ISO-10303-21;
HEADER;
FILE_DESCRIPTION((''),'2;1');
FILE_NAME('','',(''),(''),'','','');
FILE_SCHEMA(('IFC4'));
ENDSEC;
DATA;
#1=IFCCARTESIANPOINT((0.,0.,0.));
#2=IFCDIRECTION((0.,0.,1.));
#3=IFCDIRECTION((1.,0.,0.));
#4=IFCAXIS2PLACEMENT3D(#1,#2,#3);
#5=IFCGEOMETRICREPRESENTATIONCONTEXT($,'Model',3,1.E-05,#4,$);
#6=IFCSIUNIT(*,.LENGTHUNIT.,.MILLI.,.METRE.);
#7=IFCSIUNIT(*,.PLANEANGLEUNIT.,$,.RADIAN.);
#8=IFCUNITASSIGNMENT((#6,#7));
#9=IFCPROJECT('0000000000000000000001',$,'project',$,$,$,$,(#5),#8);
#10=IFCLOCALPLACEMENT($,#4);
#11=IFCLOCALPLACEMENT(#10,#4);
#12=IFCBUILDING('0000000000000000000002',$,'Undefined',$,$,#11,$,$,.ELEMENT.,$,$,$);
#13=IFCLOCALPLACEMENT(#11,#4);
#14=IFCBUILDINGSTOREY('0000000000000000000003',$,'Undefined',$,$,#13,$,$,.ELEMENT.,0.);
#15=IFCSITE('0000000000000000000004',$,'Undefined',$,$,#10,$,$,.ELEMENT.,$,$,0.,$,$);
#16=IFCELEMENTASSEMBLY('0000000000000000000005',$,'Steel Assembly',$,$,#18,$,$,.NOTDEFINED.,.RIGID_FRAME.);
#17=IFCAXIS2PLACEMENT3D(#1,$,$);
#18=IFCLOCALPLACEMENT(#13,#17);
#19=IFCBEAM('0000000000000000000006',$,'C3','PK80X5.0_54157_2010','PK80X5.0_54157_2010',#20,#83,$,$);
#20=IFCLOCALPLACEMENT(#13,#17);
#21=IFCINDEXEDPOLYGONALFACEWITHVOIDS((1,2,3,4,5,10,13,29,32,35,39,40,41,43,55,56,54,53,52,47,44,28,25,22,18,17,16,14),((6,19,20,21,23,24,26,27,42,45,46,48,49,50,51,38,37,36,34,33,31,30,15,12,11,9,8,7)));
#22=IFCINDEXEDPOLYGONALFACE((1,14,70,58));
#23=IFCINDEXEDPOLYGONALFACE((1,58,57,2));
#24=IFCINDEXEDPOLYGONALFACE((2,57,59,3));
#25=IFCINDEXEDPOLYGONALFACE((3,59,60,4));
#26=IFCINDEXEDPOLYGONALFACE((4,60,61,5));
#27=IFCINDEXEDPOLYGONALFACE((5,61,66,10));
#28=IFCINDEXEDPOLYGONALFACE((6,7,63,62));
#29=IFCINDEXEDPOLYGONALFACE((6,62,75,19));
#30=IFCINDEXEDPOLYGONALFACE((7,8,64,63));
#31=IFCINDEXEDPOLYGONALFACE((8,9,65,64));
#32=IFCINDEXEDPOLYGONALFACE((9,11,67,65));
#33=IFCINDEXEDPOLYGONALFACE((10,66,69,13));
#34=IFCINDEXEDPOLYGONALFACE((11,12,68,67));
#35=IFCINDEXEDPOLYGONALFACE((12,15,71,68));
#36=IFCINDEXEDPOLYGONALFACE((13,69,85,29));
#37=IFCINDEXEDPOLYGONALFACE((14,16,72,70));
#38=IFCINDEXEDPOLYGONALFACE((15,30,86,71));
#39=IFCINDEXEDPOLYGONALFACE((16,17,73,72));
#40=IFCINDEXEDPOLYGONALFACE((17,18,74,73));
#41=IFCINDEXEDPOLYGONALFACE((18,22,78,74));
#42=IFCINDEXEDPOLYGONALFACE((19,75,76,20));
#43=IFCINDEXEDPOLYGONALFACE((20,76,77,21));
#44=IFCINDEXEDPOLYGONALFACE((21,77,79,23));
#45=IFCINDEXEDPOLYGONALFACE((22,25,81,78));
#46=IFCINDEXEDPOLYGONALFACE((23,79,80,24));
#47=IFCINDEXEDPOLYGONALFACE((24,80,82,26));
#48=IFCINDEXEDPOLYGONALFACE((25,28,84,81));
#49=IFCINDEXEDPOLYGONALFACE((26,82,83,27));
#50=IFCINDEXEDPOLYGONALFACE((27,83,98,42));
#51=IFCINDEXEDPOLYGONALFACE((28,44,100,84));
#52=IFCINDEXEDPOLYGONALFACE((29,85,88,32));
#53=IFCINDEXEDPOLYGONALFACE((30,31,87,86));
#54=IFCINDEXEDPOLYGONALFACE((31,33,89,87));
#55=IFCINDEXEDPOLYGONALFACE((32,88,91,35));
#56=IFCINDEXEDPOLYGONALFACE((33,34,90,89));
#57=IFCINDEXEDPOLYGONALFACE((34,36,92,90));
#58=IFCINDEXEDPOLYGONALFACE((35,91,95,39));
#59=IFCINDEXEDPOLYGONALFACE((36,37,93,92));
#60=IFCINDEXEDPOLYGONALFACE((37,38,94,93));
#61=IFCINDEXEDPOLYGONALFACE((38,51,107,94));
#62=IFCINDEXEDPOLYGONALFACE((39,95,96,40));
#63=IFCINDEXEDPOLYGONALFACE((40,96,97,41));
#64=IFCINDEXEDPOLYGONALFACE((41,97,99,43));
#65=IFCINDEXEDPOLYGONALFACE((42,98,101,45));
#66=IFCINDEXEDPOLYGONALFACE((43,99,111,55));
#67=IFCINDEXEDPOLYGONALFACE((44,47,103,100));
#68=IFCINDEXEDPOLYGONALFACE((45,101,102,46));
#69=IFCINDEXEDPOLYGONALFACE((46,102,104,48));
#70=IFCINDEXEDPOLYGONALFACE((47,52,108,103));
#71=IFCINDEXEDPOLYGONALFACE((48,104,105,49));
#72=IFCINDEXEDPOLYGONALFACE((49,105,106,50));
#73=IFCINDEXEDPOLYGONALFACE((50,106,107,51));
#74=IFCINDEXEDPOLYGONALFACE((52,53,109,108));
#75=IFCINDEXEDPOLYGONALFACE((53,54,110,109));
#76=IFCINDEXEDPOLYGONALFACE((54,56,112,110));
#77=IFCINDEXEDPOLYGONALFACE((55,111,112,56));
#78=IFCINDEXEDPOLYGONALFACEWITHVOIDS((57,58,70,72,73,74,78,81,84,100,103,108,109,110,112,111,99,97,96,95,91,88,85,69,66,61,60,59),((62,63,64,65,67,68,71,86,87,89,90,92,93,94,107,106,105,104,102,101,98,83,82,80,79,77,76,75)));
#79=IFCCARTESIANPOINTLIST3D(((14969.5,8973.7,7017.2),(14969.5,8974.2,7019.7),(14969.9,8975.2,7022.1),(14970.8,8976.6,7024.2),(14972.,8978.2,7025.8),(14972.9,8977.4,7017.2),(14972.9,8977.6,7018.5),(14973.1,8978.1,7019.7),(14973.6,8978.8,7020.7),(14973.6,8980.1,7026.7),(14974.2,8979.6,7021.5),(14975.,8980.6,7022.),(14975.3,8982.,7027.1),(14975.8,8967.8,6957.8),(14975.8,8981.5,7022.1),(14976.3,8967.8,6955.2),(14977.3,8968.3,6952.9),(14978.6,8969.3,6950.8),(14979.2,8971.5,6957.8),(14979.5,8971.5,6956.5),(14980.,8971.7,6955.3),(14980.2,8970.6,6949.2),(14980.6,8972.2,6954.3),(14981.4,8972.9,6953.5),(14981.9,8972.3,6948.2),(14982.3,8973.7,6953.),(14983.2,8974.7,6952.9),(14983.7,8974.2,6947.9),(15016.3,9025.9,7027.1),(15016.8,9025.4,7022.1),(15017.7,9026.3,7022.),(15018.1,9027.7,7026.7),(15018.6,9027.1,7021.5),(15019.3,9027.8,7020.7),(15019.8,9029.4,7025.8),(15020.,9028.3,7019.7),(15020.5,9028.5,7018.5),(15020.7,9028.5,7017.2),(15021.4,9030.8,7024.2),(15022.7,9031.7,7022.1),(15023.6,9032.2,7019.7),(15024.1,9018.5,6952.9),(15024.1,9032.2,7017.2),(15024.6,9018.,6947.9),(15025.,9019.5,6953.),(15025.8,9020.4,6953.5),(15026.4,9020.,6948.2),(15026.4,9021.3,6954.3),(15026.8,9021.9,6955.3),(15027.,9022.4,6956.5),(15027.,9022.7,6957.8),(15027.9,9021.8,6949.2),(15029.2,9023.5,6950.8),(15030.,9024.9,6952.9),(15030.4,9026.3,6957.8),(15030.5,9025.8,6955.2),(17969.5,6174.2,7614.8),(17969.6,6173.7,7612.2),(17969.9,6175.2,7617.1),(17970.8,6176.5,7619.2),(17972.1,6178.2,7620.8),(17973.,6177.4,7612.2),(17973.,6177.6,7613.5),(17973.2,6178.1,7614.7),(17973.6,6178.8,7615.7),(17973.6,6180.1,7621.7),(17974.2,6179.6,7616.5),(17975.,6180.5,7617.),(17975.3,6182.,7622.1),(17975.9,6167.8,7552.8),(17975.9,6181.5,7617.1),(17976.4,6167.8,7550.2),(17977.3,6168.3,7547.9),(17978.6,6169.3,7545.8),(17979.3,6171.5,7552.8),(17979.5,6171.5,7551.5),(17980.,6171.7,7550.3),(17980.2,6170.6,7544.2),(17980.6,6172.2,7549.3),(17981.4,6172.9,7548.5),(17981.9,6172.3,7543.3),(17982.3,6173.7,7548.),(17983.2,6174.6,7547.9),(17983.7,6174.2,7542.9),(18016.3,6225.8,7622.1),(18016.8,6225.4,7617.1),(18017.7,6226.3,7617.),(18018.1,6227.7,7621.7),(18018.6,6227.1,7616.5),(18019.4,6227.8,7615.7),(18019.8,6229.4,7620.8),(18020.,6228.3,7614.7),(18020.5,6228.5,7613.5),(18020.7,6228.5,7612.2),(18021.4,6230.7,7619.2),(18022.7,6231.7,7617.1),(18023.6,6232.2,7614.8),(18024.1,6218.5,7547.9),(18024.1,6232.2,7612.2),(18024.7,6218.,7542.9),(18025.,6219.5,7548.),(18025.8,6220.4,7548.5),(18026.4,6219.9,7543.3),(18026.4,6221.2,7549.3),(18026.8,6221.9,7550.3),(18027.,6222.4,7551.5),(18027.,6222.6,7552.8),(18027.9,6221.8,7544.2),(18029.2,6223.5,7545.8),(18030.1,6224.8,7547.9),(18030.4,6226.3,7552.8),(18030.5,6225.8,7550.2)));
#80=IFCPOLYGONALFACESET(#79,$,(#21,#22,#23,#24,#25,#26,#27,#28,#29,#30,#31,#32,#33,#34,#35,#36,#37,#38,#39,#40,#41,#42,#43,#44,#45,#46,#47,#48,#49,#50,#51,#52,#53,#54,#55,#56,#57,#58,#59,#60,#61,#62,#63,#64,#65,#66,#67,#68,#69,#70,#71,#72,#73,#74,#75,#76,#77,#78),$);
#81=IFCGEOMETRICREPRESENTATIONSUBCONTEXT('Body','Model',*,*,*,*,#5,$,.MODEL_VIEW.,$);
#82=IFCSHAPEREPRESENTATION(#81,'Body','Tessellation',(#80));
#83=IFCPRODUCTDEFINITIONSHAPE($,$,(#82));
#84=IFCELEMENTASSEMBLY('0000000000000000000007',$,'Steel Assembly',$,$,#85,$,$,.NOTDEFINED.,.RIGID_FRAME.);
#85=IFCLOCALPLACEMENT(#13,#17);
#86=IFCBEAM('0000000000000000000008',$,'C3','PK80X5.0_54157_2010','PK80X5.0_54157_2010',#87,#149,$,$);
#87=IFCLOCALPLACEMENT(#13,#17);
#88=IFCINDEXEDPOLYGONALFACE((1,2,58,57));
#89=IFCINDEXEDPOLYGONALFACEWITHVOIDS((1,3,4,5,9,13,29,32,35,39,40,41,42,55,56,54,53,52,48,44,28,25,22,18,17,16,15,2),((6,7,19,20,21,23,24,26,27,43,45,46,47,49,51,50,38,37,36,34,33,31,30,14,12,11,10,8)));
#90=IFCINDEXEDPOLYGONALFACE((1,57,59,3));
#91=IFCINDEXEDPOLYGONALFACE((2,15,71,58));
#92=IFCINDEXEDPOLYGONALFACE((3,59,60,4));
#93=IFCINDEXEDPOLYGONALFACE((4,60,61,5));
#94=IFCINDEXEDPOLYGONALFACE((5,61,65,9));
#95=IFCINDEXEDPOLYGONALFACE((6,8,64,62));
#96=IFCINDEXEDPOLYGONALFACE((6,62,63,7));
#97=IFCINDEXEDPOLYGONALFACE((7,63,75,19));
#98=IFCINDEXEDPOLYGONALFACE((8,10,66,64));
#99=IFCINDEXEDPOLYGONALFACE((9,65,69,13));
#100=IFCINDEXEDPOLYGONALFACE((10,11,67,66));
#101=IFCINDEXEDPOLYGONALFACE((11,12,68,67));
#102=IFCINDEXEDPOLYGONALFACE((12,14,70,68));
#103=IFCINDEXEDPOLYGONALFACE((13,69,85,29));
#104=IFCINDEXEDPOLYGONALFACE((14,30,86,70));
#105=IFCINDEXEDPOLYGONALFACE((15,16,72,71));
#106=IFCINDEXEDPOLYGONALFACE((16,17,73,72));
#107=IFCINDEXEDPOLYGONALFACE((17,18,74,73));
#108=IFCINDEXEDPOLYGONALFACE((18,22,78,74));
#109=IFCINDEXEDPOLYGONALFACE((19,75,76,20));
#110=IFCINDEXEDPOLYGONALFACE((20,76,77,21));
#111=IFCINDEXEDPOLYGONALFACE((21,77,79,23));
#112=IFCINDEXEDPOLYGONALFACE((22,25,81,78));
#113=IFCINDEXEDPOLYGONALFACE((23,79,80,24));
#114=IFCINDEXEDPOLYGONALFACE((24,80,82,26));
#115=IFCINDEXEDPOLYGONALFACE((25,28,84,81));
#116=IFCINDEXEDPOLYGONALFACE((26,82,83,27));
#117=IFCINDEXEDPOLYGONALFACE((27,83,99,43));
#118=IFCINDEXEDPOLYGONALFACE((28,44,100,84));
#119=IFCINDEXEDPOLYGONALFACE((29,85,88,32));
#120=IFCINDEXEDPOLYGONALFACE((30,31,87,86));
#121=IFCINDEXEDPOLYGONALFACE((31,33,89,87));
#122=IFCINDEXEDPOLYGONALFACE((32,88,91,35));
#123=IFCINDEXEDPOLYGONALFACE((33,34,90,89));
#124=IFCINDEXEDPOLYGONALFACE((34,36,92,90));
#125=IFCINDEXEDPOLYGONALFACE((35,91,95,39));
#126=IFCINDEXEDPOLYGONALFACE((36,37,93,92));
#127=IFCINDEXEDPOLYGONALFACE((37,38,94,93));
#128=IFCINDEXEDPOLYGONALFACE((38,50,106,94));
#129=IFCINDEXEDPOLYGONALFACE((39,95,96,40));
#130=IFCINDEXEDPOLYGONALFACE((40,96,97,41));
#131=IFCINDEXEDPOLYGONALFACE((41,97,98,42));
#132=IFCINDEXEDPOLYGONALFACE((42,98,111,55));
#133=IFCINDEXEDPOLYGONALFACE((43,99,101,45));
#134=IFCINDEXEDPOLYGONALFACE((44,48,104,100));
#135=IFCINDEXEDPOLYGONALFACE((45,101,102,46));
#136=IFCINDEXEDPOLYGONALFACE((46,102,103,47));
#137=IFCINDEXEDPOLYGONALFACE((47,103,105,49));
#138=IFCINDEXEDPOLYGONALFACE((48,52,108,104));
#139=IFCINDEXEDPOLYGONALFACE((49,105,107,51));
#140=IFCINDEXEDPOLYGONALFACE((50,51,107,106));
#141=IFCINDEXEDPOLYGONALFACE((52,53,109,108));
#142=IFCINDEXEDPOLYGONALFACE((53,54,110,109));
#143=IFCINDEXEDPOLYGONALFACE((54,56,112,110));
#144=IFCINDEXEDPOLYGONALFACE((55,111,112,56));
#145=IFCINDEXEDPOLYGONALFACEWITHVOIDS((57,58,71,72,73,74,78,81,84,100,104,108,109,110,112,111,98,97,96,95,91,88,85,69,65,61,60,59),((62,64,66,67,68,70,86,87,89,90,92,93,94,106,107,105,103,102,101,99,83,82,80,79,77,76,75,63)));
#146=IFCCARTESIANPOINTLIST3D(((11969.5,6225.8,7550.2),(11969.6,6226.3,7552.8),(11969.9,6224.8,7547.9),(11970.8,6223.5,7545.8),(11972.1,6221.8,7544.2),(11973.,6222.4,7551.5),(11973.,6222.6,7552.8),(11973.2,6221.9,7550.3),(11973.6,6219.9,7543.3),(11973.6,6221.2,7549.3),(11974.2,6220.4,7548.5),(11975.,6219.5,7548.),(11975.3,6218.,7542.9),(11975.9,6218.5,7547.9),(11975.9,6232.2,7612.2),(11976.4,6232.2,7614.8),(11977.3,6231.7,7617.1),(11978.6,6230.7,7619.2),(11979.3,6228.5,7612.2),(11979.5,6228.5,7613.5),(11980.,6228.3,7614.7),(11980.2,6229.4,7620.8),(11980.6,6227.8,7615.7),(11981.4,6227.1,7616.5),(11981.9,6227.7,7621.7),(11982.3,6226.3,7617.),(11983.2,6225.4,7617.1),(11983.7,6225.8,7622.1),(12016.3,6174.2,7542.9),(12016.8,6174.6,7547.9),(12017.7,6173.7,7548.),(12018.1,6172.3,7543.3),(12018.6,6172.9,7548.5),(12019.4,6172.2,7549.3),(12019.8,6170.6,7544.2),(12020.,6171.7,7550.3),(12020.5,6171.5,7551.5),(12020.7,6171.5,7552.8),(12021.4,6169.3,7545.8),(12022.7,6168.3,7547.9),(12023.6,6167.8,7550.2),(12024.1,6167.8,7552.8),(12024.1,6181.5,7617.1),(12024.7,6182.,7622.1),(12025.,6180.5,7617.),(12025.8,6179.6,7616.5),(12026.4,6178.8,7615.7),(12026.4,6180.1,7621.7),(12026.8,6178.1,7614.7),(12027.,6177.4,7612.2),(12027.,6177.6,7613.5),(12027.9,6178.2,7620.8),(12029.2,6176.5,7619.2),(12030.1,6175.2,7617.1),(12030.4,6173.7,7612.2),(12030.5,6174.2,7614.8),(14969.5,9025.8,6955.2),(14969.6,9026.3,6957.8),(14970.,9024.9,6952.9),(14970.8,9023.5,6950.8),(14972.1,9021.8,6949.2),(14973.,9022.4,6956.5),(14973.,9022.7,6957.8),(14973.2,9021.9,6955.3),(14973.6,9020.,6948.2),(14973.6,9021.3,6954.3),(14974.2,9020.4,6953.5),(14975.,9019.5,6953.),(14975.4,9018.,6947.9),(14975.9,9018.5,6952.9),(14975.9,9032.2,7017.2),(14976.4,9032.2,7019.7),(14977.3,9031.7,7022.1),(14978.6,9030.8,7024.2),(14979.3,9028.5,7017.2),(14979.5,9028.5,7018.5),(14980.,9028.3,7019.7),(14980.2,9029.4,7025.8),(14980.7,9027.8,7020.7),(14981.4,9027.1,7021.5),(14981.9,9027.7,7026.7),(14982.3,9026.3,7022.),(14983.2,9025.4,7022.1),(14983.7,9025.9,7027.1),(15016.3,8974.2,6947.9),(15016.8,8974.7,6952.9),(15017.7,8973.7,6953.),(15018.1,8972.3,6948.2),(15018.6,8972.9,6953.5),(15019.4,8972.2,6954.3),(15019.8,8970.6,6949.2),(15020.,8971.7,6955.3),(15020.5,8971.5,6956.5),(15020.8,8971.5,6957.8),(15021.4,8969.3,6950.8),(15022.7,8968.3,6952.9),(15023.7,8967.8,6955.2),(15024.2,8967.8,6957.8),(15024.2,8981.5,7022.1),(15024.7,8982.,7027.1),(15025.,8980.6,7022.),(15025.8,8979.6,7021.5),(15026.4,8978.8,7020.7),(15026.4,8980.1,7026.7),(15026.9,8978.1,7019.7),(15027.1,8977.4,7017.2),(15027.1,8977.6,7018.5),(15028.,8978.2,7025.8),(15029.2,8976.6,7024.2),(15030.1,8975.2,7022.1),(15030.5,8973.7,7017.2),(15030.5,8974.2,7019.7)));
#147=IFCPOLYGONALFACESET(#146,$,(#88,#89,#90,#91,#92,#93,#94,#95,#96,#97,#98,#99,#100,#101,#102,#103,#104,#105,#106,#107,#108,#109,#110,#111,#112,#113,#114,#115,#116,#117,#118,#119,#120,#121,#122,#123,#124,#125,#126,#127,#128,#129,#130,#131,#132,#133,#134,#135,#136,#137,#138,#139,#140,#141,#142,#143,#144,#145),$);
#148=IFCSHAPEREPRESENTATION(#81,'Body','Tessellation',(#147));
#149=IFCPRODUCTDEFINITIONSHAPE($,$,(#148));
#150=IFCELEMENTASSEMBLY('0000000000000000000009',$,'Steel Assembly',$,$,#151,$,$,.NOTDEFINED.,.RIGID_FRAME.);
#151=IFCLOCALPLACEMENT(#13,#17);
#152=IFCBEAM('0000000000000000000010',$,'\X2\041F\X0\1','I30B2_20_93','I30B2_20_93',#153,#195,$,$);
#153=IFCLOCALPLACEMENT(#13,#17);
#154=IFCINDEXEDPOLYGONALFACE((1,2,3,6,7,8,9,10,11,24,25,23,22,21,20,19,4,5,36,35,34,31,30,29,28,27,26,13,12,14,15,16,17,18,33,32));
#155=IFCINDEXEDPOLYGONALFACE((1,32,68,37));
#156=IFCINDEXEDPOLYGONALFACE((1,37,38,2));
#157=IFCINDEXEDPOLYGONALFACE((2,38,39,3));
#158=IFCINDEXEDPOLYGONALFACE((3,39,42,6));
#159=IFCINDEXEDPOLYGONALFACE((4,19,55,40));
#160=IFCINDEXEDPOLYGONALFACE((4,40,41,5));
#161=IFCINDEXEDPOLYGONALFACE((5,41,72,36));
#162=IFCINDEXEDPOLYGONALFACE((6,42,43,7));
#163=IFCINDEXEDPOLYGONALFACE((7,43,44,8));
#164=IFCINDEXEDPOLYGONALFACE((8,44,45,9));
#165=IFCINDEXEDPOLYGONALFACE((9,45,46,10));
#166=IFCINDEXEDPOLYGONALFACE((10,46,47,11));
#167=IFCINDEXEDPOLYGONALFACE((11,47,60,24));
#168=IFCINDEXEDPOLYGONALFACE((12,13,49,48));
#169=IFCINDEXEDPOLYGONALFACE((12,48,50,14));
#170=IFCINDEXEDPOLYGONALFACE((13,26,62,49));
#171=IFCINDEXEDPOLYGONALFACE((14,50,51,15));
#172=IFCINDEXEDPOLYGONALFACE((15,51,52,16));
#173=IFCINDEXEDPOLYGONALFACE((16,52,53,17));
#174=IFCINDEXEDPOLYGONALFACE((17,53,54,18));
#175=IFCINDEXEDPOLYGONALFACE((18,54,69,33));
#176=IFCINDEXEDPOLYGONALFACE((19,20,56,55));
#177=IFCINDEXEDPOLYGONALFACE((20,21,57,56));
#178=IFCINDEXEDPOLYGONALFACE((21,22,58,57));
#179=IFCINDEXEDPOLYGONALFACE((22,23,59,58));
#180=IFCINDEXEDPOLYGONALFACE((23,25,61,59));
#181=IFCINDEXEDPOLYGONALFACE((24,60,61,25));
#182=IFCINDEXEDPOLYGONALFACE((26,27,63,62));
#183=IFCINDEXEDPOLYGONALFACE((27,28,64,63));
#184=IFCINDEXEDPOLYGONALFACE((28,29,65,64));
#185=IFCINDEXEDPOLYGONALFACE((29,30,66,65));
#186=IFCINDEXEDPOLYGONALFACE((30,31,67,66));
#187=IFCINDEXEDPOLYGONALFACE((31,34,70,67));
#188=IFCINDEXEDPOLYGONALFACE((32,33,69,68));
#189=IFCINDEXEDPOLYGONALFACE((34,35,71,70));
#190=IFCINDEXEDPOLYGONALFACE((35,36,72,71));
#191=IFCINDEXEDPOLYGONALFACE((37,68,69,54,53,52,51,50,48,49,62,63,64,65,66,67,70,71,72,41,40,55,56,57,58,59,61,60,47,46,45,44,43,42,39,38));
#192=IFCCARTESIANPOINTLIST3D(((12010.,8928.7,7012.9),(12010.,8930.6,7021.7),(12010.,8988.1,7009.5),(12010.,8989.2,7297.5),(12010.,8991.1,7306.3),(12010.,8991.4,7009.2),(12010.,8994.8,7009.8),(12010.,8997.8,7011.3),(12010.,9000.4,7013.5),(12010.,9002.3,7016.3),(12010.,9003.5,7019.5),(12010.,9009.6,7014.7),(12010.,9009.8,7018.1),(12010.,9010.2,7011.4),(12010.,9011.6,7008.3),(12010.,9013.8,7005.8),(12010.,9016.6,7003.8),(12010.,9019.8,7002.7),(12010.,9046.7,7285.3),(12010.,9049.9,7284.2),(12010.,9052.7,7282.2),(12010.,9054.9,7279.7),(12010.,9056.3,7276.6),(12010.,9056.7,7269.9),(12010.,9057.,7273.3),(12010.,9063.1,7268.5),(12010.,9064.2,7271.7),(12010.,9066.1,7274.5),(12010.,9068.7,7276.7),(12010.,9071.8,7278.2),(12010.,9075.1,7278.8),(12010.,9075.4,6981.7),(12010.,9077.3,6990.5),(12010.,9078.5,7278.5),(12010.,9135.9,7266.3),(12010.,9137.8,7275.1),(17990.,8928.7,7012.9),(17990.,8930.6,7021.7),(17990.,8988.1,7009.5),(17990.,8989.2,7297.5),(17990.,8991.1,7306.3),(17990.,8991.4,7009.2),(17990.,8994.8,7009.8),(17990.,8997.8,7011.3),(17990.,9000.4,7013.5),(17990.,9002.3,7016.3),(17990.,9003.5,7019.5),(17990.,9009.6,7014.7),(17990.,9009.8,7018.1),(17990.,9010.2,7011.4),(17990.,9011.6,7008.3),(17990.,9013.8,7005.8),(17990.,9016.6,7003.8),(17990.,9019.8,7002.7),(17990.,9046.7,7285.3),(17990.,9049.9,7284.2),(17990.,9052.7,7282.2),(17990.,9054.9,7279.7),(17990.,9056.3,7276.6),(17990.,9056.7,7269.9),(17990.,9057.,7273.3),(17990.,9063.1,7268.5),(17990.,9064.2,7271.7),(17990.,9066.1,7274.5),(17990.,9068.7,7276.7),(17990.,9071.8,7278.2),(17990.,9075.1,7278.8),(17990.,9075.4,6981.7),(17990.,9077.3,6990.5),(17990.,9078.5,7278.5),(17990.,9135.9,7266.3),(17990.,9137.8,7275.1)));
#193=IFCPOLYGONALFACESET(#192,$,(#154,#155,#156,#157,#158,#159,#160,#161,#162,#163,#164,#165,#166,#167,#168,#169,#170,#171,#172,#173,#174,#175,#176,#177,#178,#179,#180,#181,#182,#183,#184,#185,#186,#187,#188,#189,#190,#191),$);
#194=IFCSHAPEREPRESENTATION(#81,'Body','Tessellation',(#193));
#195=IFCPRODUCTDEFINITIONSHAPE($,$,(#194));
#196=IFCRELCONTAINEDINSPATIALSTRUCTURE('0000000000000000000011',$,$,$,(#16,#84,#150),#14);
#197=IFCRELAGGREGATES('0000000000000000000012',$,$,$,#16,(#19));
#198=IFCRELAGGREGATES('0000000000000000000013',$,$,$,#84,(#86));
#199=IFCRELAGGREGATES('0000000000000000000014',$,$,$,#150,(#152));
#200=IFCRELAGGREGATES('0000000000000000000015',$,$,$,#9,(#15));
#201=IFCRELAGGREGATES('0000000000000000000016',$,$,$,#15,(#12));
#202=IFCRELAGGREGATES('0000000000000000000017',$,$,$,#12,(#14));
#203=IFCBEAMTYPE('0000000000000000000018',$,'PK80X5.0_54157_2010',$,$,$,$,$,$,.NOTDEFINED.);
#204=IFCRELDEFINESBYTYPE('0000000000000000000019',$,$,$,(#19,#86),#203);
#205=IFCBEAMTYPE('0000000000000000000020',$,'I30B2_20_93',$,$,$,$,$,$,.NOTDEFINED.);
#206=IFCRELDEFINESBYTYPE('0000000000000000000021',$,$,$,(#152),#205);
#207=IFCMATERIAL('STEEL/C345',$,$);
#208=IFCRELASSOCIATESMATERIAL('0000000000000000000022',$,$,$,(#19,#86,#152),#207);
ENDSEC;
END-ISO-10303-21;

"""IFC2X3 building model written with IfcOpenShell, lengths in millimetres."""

from ifc_helpers import new_model, si_unit, frame, origin_with_axes, origin_2d_with_axis, place, context, subcontext, project, spatial, hollow_rectangle, i_section, extrude, material, type_object, element, aggregate, save


model = new_model("IFC2X3")

# Units and contexts
model_context = context("Model", 3, precision=1e-05, world=origin_with_axes())
body_context = subcontext(model_context, "Body", "Model", "MODEL_VIEW")
ifc_project = project(units=[si_unit("LENGTHUNIT", "METRE", prefix="MILLI"), si_unit("PLANEANGLEUNIT", "RADIAN")], contexts=[model_context])

# Site, building, storey
site_placement = place(None, origin_with_axes())
site = spatial("IfcSite", under=ifc_project, at=site_placement, Name="Undefined", CompositionType="ELEMENT", RefElevation=0.0)
building_placement = place(site_placement, origin_with_axes())
building = spatial("IfcBuilding", under=site, at=building_placement, Name="Undefined", CompositionType="ELEMENT")
storey_placement = place(building_placement, origin_with_axes())
storey = spatial("IfcBuildingStorey", under=building, at=storey_placement, Name="Undefined", CompositionType="ELEMENT", Elevation=0.0)

# Element assemblies, beams
ifc_material = material(Name="STEEL/C345")
assembly_1_placement = place(storey_placement, origin_with_axes())
assembly_1 = element("IfcElementAssembly", 1, at=assembly_1_placement, inside=storey, Name="Steel Assembly", AssemblyPlace="NOTDEFINED", PredefinedType="RIGID_FRAME")
beam_type_1 = type_object("IfcBeamType", Name="PK80X5.0_54157_2010", PredefinedType="NOTDEFINED")
beam_1_placement = place(assembly_1_placement, frame((15000.0, 9000.0, 6987.5), z_axis=(-0.104901, 0.097907, 0.989651), x_axis=(0.72349, -0.675257, 0.143492)))
beam_1 = element("IfcBeam", 2, at=beam_1_placement, type_object=beam_type_1, material=ifc_material, Name="C3", Description="PK80X5.0_54157_2010", ObjectType="PK80X5.0_54157_2010", context=body_context, shape_type="SweptSolid", body=[
    extrude(hollow_rectangle(XDim=80.0, YDim=80.0, WallThickness=5.0, InnerFilletRadius=5.0, OuterFilletRadius=10.0, at=origin_2d_with_axis()), frame((4146.6, 0.0, 0.0), z_axis=(-1.0, 0.0, 0.0), x_axis=(0.0, -1.0, 0.0)), (0.0, 0.0, 1.0), 4146.6),
])
aggregate(assembly_1, [beam_1])
assembly_2_placement = place(storey_placement, origin_with_axes())
assembly_2 = element("IfcElementAssembly", 3, at=assembly_2_placement, inside=storey, Name="Steel Assembly", AssemblyPlace="NOTDEFINED", PredefinedType="RIGID_FRAME")
beam_2_placement = place(assembly_2_placement, frame((15000.0, 9000.0, 6987.5), z_axis=(0.104901, 0.097907, 0.989651), x_axis=(-0.72349, -0.675257, 0.143492)))
beam_2 = element("IfcBeam", 4, at=beam_2_placement, type_object=beam_type_1, material=ifc_material, Name="C3", Description="PK80X5.0_54157_2010", ObjectType="PK80X5.0_54157_2010", context=body_context, shape_type="SweptSolid", body=[
    extrude(hollow_rectangle(XDim=80.0, YDim=80.0, WallThickness=5.0, InnerFilletRadius=5.0, OuterFilletRadius=10.0, at=origin_2d_with_axis()), frame((4146.6, 0.0, 0.0), z_axis=(-1.0, 0.0, 0.0), x_axis=(0.0, -1.0, 0.0)), (0.0, 0.0, 1.0), 4146.6),
])
aggregate(assembly_2, [beam_2])
assembly_3_placement = place(storey_placement, origin_with_axes())
assembly_3 = element("IfcElementAssembly", 5, at=assembly_3_placement, inside=storey, Name="Steel Assembly", AssemblyPlace="NOTDEFINED", PredefinedType="RIGID_FRAME")
beam_type_2 = type_object("IfcBeamType", Name="I30B2_20_93", PredefinedType="NOTDEFINED")
beam_3_placement = place(assembly_3_placement, frame((17990.0, 9033.3, 7144.0), z_axis=(0.0, -0.207912, -0.978148), x_axis=(-1.0, 0.0, 0.0)))
beam_3 = element("IfcBeam", 6, at=beam_3_placement, type_object=beam_type_2, material=ifc_material, Name="П1", Description="I30B2_20_93", ObjectType="I30B2_20_93", context=body_context, shape_type="SweptSolid", body=[
    extrude(i_section(OverallWidth=150.0, OverallDepth=300.0, WebThickness=6.5, FlangeThickness=9.0, FilletRadius=13.0, at=origin_2d_with_axis()), frame((5980.0, 0.0, 0.0), z_axis=(-1.0, 0.0, 0.0), x_axis=(0.0, -1.0, 0.0)), (0.0, 0.0, 1.0), 5980.0),
])
aggregate(assembly_3, [beam_3])

save(model, "model.ifc")
